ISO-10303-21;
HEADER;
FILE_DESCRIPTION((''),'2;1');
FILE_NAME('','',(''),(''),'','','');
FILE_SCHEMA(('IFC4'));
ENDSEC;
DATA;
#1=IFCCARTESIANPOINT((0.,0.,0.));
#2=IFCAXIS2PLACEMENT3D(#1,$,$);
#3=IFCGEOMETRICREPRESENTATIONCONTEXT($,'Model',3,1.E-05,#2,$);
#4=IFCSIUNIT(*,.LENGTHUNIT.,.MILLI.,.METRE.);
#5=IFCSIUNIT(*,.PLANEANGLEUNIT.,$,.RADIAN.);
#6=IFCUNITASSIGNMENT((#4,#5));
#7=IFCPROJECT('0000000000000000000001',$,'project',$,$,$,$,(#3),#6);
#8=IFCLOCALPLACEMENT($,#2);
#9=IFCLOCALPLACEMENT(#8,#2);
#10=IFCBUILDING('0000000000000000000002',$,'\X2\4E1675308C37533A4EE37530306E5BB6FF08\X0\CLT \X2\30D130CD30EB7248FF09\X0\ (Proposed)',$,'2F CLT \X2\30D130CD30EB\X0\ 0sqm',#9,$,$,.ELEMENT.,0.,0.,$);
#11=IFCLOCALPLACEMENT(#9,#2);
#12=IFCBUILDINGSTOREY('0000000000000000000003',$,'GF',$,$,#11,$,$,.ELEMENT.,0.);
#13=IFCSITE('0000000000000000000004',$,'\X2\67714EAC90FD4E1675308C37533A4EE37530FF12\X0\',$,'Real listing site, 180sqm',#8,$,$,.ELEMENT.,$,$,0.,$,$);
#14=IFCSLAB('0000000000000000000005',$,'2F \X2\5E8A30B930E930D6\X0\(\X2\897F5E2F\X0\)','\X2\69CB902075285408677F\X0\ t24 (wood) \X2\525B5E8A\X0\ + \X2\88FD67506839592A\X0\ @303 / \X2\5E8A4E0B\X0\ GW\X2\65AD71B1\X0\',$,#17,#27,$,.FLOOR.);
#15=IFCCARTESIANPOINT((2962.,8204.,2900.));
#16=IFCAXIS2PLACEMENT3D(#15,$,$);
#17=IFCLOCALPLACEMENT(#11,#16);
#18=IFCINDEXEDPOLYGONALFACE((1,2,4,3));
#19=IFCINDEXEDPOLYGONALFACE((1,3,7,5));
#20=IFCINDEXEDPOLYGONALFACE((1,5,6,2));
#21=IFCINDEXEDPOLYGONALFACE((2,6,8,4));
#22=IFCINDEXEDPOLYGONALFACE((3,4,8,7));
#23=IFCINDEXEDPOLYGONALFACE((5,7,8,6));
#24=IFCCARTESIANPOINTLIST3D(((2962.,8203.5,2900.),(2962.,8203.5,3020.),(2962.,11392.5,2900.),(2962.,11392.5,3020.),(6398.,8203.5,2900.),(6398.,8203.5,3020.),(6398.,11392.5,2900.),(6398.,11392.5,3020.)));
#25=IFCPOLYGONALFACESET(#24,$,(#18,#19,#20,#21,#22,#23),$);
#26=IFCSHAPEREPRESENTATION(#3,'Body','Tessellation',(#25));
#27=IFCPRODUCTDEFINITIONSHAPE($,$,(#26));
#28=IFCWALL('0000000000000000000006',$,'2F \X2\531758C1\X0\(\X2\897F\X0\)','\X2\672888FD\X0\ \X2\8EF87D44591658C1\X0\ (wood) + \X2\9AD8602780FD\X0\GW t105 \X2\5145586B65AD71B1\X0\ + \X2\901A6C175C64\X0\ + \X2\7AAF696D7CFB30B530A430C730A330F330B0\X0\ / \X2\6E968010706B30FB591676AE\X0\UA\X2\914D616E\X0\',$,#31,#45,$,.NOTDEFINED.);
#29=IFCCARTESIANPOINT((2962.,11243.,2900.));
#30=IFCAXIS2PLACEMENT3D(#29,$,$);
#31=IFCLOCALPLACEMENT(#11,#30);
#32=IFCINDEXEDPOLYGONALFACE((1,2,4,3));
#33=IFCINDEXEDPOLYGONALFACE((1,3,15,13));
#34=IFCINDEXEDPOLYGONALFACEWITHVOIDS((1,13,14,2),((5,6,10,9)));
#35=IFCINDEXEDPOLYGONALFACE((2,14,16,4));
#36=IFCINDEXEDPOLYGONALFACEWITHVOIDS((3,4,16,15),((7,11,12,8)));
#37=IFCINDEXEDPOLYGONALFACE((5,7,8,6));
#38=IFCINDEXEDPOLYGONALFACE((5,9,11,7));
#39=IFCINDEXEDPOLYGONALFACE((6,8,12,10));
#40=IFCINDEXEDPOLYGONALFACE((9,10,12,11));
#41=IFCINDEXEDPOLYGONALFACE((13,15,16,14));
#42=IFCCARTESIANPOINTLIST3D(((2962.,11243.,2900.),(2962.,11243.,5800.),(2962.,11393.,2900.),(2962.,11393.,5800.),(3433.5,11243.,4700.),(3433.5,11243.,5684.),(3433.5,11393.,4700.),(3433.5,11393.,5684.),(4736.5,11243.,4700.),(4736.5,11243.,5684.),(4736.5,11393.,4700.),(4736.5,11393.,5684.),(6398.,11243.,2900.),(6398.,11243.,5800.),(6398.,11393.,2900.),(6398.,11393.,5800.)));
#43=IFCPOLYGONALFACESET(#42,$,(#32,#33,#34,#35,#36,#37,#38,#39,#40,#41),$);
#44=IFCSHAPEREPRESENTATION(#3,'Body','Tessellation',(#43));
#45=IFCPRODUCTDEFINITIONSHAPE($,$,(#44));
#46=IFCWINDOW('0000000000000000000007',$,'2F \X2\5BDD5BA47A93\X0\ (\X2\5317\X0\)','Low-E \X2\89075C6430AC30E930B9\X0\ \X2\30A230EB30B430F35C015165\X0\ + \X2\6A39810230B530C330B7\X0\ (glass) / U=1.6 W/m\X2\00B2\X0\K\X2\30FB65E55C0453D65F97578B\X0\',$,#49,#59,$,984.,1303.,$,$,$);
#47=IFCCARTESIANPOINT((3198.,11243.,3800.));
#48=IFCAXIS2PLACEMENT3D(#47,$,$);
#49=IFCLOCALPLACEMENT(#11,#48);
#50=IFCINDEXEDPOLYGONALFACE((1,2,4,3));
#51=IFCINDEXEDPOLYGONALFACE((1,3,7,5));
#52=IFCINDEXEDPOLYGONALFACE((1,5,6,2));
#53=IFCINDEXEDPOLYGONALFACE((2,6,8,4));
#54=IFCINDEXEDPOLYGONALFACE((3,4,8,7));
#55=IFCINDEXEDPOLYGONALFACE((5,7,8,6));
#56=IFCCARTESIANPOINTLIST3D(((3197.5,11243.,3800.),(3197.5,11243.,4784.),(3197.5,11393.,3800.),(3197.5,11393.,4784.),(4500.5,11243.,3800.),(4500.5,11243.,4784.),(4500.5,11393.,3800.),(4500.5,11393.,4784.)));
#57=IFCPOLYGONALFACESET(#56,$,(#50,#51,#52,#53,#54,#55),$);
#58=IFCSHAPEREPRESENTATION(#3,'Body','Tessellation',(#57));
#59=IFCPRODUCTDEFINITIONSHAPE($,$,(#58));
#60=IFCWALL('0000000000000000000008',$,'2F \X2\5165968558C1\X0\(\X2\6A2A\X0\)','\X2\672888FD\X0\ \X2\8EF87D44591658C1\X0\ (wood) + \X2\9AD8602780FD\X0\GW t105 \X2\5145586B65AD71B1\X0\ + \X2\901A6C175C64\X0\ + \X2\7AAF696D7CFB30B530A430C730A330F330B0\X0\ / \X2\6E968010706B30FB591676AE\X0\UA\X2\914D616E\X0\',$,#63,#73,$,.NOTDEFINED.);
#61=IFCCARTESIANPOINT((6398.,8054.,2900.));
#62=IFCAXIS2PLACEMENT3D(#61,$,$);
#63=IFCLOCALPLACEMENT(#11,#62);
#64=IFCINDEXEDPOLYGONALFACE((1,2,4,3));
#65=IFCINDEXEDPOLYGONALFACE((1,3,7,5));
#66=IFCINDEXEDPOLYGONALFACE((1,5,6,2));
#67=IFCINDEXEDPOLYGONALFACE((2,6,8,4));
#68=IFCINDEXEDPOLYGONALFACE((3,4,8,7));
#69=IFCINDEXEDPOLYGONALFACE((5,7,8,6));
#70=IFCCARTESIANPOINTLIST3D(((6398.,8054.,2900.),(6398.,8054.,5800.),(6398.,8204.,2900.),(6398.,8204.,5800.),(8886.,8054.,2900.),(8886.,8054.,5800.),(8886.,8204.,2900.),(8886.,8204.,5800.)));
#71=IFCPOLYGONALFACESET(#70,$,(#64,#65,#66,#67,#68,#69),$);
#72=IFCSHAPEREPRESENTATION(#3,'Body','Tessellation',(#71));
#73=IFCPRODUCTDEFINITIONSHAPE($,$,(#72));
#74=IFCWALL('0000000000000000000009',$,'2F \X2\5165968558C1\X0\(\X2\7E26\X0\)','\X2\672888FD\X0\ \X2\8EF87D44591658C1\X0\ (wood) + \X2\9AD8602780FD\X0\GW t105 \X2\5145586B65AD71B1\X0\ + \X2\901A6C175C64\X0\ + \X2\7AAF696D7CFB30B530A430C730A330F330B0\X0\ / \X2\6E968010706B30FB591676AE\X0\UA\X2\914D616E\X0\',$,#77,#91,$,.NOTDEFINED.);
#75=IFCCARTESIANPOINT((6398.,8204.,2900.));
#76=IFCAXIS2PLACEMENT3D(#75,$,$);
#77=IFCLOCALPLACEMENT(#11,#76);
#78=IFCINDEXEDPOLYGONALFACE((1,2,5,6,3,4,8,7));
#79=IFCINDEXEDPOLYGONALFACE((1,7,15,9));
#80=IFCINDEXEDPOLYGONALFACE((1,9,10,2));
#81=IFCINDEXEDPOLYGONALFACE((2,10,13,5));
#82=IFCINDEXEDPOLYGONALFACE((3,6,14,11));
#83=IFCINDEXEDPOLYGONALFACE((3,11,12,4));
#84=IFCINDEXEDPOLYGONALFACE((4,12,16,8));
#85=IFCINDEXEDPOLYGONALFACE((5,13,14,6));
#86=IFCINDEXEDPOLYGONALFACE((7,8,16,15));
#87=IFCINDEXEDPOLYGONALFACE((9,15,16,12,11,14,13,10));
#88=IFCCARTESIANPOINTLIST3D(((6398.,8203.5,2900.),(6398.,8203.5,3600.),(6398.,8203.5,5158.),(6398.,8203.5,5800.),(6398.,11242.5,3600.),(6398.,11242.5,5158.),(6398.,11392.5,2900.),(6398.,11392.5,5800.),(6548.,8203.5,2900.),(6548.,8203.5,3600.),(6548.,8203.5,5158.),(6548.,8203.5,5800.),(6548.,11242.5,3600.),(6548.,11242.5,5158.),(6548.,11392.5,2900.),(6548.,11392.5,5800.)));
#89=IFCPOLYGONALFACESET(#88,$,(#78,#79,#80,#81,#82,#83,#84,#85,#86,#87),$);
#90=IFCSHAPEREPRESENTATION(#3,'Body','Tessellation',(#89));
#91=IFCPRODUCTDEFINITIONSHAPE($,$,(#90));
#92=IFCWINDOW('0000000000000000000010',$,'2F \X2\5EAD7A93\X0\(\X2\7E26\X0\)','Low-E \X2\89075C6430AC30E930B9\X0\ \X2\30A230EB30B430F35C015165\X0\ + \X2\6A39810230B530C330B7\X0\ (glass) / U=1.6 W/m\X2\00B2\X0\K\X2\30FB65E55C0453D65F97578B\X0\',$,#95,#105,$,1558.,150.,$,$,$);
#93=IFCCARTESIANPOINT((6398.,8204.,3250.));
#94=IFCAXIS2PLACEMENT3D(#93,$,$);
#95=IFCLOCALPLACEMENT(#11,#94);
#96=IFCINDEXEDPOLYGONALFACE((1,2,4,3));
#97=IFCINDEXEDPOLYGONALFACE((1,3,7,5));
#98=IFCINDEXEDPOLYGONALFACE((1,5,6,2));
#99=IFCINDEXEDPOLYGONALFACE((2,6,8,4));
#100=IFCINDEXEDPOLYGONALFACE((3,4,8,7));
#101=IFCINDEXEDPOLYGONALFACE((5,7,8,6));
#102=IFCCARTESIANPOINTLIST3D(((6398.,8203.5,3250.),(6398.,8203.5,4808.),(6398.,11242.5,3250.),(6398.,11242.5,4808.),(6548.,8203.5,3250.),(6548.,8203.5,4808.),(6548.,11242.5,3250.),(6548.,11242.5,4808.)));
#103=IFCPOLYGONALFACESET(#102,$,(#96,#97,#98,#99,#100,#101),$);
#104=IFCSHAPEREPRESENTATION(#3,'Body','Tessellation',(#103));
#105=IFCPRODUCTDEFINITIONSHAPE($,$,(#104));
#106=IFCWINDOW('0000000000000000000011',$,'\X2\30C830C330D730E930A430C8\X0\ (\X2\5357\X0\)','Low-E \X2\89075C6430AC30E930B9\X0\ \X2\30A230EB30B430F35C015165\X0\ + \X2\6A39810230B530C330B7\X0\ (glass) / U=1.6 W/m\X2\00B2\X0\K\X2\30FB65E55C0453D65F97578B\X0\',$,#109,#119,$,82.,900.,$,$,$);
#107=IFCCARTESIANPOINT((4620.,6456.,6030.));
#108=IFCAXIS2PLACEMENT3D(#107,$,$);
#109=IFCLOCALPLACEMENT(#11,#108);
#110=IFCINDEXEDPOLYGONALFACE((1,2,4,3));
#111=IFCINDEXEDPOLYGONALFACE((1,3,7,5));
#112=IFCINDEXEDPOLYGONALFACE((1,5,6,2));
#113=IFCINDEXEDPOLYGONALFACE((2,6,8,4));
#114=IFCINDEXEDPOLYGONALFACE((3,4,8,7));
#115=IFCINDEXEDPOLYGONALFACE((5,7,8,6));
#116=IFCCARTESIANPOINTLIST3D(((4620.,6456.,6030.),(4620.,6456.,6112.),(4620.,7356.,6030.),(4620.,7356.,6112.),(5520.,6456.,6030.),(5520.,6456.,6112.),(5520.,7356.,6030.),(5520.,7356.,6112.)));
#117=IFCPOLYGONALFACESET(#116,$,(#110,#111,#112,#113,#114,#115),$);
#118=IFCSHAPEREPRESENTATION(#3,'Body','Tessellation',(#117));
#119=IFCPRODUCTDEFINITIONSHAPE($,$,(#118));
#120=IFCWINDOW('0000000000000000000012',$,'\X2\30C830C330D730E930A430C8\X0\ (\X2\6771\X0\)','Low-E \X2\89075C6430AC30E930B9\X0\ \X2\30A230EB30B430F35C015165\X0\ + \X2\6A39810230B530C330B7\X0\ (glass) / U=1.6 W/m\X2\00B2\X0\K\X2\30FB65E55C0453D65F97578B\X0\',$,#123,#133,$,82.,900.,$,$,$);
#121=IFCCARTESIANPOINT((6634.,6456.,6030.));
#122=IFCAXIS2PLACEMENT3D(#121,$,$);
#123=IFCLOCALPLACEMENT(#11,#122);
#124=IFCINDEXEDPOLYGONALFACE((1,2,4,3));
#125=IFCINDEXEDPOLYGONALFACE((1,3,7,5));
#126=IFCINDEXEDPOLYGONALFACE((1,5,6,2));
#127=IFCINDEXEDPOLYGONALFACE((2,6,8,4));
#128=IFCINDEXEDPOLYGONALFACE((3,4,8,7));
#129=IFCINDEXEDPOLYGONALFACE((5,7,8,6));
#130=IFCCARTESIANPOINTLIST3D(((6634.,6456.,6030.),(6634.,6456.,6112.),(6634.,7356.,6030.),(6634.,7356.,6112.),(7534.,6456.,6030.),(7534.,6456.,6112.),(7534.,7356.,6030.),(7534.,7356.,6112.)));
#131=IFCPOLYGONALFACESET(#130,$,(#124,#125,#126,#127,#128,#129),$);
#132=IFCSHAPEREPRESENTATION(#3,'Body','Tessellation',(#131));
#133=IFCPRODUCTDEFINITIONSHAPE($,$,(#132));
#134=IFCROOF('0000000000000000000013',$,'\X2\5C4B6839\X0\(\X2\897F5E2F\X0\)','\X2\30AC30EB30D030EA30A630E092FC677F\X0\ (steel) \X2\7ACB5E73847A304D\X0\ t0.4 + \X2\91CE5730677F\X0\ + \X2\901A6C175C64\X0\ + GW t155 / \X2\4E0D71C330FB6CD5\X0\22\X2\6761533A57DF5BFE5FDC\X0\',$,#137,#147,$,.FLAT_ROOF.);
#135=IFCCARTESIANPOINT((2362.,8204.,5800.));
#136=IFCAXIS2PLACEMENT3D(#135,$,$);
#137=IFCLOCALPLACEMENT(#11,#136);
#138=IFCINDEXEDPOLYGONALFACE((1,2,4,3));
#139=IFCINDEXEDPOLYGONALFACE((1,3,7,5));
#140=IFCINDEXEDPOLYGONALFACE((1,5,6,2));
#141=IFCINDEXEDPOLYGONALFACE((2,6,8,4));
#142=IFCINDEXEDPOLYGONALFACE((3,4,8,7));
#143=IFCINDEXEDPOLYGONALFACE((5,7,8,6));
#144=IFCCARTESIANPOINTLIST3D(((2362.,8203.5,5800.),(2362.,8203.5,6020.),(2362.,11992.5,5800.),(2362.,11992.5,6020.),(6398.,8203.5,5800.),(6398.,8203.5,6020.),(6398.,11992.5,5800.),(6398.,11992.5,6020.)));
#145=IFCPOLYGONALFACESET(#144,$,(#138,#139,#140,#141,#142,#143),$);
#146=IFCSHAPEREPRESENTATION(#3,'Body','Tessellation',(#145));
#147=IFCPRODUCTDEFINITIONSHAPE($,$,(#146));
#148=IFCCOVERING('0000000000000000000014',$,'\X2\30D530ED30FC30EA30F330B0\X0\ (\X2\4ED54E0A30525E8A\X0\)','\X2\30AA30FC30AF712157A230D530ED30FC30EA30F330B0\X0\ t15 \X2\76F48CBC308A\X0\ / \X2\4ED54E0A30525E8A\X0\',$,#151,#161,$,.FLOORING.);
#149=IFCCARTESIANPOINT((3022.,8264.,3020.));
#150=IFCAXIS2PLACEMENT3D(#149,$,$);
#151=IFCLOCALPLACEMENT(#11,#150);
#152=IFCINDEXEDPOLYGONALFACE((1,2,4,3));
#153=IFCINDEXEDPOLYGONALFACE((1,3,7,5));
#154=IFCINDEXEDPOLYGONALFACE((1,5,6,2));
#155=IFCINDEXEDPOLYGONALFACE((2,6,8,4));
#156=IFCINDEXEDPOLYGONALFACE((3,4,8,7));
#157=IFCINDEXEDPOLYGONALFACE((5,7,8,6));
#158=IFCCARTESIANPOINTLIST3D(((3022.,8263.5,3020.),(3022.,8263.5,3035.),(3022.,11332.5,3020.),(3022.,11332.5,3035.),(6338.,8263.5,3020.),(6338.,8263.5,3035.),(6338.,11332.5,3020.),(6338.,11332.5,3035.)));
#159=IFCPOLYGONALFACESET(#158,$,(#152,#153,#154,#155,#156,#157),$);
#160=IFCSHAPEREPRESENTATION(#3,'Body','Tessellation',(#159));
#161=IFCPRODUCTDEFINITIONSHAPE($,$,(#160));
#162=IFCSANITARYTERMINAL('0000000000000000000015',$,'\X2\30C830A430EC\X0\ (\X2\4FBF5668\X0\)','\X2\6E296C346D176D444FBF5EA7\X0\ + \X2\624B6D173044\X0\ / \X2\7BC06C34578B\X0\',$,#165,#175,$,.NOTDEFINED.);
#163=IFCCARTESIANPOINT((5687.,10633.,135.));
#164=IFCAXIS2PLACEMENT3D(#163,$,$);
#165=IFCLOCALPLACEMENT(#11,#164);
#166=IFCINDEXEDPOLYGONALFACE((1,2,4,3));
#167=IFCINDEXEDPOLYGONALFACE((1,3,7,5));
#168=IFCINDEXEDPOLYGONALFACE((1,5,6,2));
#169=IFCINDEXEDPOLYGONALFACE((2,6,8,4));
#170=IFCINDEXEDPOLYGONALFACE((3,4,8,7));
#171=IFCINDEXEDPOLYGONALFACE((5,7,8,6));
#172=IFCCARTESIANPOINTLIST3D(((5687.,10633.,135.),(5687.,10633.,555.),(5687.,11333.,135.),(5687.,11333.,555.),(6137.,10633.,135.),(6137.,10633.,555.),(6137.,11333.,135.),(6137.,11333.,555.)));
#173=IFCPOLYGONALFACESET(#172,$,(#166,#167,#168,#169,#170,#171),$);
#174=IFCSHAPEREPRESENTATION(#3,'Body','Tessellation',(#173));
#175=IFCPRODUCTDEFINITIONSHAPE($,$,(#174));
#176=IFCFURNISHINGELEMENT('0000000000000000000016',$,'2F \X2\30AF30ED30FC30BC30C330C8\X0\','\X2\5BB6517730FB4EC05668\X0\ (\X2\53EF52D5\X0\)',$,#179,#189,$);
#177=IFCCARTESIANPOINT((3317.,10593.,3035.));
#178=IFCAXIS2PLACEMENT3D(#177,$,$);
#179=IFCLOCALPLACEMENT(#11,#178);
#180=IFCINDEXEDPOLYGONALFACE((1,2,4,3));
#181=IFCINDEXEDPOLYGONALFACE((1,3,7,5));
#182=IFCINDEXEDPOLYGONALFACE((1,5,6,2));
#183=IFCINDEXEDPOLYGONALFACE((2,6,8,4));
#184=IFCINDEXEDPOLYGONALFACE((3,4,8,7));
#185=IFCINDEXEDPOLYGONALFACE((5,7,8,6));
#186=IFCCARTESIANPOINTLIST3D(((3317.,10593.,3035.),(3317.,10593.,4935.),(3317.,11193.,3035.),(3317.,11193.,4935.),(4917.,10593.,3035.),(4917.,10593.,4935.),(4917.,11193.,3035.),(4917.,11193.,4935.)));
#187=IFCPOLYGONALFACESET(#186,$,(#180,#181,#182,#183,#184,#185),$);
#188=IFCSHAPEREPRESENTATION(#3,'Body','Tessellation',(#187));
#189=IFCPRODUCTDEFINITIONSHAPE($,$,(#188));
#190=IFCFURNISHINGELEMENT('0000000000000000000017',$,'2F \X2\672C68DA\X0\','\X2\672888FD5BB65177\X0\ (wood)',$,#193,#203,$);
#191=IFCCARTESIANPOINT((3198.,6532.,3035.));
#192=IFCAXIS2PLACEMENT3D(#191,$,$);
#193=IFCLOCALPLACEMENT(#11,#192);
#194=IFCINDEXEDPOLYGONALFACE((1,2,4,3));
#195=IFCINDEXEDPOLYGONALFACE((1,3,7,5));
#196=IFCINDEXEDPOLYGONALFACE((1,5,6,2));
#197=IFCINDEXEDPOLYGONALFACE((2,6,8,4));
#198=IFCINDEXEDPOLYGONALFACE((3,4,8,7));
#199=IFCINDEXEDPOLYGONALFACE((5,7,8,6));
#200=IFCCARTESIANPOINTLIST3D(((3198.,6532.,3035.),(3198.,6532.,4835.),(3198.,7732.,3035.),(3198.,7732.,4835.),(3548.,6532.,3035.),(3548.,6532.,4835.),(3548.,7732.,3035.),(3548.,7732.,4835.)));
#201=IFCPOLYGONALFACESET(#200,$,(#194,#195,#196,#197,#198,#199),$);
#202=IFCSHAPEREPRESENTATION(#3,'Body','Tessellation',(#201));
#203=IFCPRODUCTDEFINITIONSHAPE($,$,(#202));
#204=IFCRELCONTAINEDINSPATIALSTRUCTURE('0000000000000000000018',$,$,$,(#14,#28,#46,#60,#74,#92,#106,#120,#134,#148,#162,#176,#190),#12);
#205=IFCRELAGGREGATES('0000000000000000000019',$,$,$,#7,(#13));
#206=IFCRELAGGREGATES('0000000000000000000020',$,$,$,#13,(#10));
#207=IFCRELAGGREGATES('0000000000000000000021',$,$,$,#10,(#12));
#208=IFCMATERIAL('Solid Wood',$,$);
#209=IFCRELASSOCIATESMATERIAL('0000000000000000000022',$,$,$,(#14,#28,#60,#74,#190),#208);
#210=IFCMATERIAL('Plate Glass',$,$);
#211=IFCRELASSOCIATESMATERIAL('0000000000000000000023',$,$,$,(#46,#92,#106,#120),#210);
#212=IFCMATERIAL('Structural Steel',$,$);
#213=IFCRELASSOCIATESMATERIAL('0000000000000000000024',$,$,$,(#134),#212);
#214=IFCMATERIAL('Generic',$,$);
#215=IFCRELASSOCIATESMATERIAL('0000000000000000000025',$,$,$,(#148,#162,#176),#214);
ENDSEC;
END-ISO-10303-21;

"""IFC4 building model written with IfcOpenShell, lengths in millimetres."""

from ifc_helpers import new_model, si_unit, frame, frame_2d, origin, place, context, project, spatial, rectangle, extrude, material, element, fill, save


model = new_model("IFC4")

# Units and contexts
model_context = context("Model", 3, precision=1e-05, world=origin())
ifc_project = project(units=[si_unit("LENGTHUNIT", "METRE", prefix="MILLI"), si_unit("PLANEANGLEUNIT", "RADIAN")], contexts=[model_context])

# Site, building, storey
site_placement = place(None, origin())
site = spatial("IfcSite", under=ifc_project, at=site_placement, Name="東京都世田谷区代田２", ObjectType="Real listing site, 180sqm", CompositionType="ELEMENT", RefElevation=0.0)
building_placement = place(site_placement, origin())
building = spatial("IfcBuilding", under=site, at=building_placement, Name="世田谷区代田の家（CLT パネル版） (Proposed)", ObjectType="2F CLT パネル 0sqm", CompositionType="ELEMENT", ElevationOfRefHeight=0.0, ElevationOfTerrain=0.0)
storey_placement = place(building_placement, origin())
storey = spatial("IfcBuildingStorey", under=building, at=storey_placement, Name="GF", CompositionType="ELEMENT", Elevation=0.0)

# Slab
ifc_material_1 = material(Name="Solid Wood")
slab_placement = place(storey_placement, frame((2962.0, 8204.0, 2900.0)))
element("IfcSlab", 1, at=slab_placement, inside=storey, material=ifc_material_1, Name="2F 床スラブ(西帯)", Description="構造用合板 t24 (wood) 剛床 + 製材根太 @303 / 床下 GW断熱", PredefinedType="FLOOR", context=model_context, shape_type="SweptSolid", body=[
    extrude(rectangle(XDim=3436.0, YDim=3189.0, at=frame_2d((1718.0, 1594.0))), frame((2962.0, 8204.0, 2900.0)), (0.0, 0.0, 1.0), 120.0),
])

# Wall, opening, window
wall_1_placement = place(storey_placement, frame((2962.0, 11243.0, 2900.0)))
wall_1 = element("IfcWall", 2, at=wall_1_placement, inside=storey, material=ifc_material_1, Name="2F 北壁(西)", Description="木製 軸組外壁 (wood) + 高性能GW t105 充填断熱 + 通気層 + 窯業系サイディング / 準耐火・外皮UA配慮", PredefinedType="NOTDEFINED", context=model_context, shape_type="SweptSolid", body=[
    extrude(rectangle(XDim=3436.0, YDim=150.0, at=frame_2d((1718.0, 75.0))), frame((2962.0, 11243.0, 2900.0)), (0.0, 0.0, 1.0), 2900.0),
])
opening_1_placement = place(storey_placement, frame((3198.0, 11243.0, 3800.0)))
opening_1 = element("IfcOpeningElement", 3, at=opening_1_placement, cuts=wall_1, PredefinedType="NOTDEFINED", context=model_context, shape_type="SweptSolid", body=[
    extrude(rectangle(XDim=1303.0, YDim=150.0, at=frame_2d((651.0, 75.0))), frame((3198.0, 11243.0, 3800.0)), (0.0, 0.0, 1.0), 984.0),
])
ifc_material_2 = material(Name="Plate Glass")
window_1_placement = place(storey_placement, frame((3198.0, 11243.0, 3800.0)))
window_1 = element("IfcWindow", 4, at=window_1_placement, inside=storey, material=ifc_material_2, Name="2F 寝室窓 (北)", Description="Low-E 複層ガラス アルゴン封入 + 樹脂サッシ (glass) / U=1.6 W/m²K・日射取得型", OverallHeight=984.0, OverallWidth=1303.0, context=model_context, shape_type="SweptSolid", body=[
    extrude(rectangle(XDim=1303.0, YDim=150.0, at=frame_2d((651.0, 75.0))), frame((3198.0, 11243.0, 3800.0)), (0.0, 0.0, 1.0), 984.0),
])
fill(opening_1, window_1)

# Wall
wall_2_placement = place(storey_placement, frame((6398.0, 8054.0, 2900.0)))
element("IfcWall", 5, at=wall_2_placement, inside=storey, material=ifc_material_1, Name="2F 入隅壁(横)", Description="木製 軸組外壁 (wood) + 高性能GW t105 充填断熱 + 通気層 + 窯業系サイディング / 準耐火・外皮UA配慮", PredefinedType="NOTDEFINED", context=model_context, shape_type="SweptSolid", body=[
    extrude(rectangle(XDim=2488.0, YDim=150.0, at=frame_2d((1244.0, 75.0))), frame((6398.0, 8054.0, 2900.0)), (0.0, 0.0, 1.0), 2900.0),
])

# Wall, opening, window
wall_3_placement = place(storey_placement, frame((6398.0, 8204.0, 2900.0)))
wall_3 = element("IfcWall", 6, at=wall_3_placement, inside=storey, material=ifc_material_1, Name="2F 入隅壁(縦)", Description="木製 軸組外壁 (wood) + 高性能GW t105 充填断熱 + 通気層 + 窯業系サイディング / 準耐火・外皮UA配慮", PredefinedType="NOTDEFINED", context=model_context, shape_type="SweptSolid", body=[
    extrude(rectangle(XDim=150.0, YDim=3189.0, at=frame_2d((75.0, 1594.0))), frame((6398.0, 8204.0, 2900.0)), (0.0, 0.0, 1.0), 2900.0),
])
opening_2_placement = place(storey_placement, frame((6398.0, 8204.0, 3250.0)))
opening_2 = element("IfcOpeningElement", 7, at=opening_2_placement, cuts=wall_3, PredefinedType="NOTDEFINED", context=model_context, shape_type="SweptSolid", body=[
    extrude(rectangle(XDim=150.0, YDim=3039.0, at=frame_2d((75.0, 1519.0))), frame((6398.0, 8204.0, 3250.0)), (0.0, 0.0, 1.0), 1558.0),
])
window_2_placement = place(storey_placement, frame((6398.0, 8204.0, 3250.0)))
window_2 = element("IfcWindow", 8, at=window_2_placement, inside=storey, material=ifc_material_2, Name="2F 庭窓(縦)", Description="Low-E 複層ガラス アルゴン封入 + 樹脂サッシ (glass) / U=1.6 W/m²K・日射取得型", OverallHeight=1558.0, OverallWidth=150.0, context=model_context, shape_type="SweptSolid", body=[
    extrude(rectangle(XDim=150.0, YDim=3039.0, at=frame_2d((75.0, 1519.0))), frame((6398.0, 8204.0, 3250.0)), (0.0, 0.0, 1.0), 1558.0),
])
fill(opening_2, window_2)

# Windows
window_3_placement = place(storey_placement, frame((4620.0, 6456.0, 6030.0)))
element("IfcWindow", 9, at=window_3_placement, inside=storey, material=ifc_material_2, Name="トップライト (南)", Description="Low-E 複層ガラス アルゴン封入 + 樹脂サッシ (glass) / U=1.6 W/m²K・日射取得型", OverallHeight=82.0, OverallWidth=900.0, context=model_context, shape_type="SweptSolid", body=[
    extrude(rectangle(XDim=900.0, YDim=900.0, at=frame_2d((450.0, 450.0))), frame((4620.0, 6456.0, 6030.0)), (0.0, 0.0, 1.0), 82.0),
])
window_4_placement = place(storey_placement, frame((6634.0, 6456.0, 6030.0)))
element("IfcWindow", 10, at=window_4_placement, inside=storey, material=ifc_material_2, Name="トップライト (東)", Description="Low-E 複層ガラス アルゴン封入 + 樹脂サッシ (glass) / U=1.6 W/m²K・日射取得型", OverallHeight=82.0, OverallWidth=900.0, context=model_context, shape_type="SweptSolid", body=[
    extrude(rectangle(XDim=900.0, YDim=900.0, at=frame_2d((450.0, 450.0))), frame((6634.0, 6456.0, 6030.0)), (0.0, 0.0, 1.0), 82.0),
])

# Roof
ifc_material_3 = material(Name="Structural Steel")
for number, where, name in (
    (11, (2362.0, 8204.0, 5800.0), "屋根(西帯)"),
):
    element("IfcRoof", number, at=place(storey_placement, frame(where)), inside=storey, material=ifc_material_3, Name=name, Description="ガルバリウム鋼板 (steel) 立平葺き t0.4 + 野地板 + 通気層 + GW t155 / 不燃・法22条区域対応", PredefinedType="FLAT_ROOF", context=model_context, shape_type="SweptSolid", body=[
        extrude(rectangle(XDim=4036.0, YDim=3789.0, at=frame_2d((2018.0, 1894.0))), frame((2362.0, 8204.0, 5800.0)), (0.0, 0.0, 1.0), 220.0),
    ])

# Covering
ifc_material_4 = material(Name="Generic")
covering_placement = place(storey_placement, frame((3022.0, 8264.0, 3020.0)))
element("IfcCovering", 12, at=covering_placement, inside=storey, material=ifc_material_4, Name="フローリング (仕上げ床)", Description="オーク無垢フローリング t15 直貼り / 仕上げ床", PredefinedType="FLOORING", context=model_context, shape_type="SweptSolid", body=[
    extrude(rectangle(XDim=3316.0, YDim=3069.0, at=frame_2d((1658.0, 1534.0))), frame((3022.0, 8264.0, 3020.0)), (0.0, 0.0, 1.0), 15.0),
])

# Sanitary terminal
sanitary_terminal_placement = place(storey_placement, frame((5687.0, 10633.0, 135.0)))
element("IfcSanitaryTerminal", 13, at=sanitary_terminal_placement, inside=storey, material=ifc_material_4, Name="トイレ (便器)", Description="温水洗浄便座 + 手洗い / 節水型", PredefinedType="NOTDEFINED", context=model_context, shape_type="SweptSolid", body=[
    extrude(rectangle(XDim=450.0, YDim=700.0, at=frame_2d((225.0, 350.0))), frame((5687.0, 10633.0, 135.0)), (0.0, 0.0, 1.0), 420.0),
])

# Furnishing elements
furnishing_1_placement = place(storey_placement, frame((3317.0, 10593.0, 3035.0)))
element("IfcFurnishingElement", 14, at=furnishing_1_placement, inside=storey, material=ifc_material_4, Name="2F クローゼット", Description="家具・什器 (可動)", context=model_context, shape_type="SweptSolid", body=[
    extrude(rectangle(XDim=1600.0, YDim=600.0, at=frame_2d((800.0, 300.0))), frame((3317.0, 10593.0, 3035.0)), (0.0, 0.0, 1.0), 1900.0),
])
furnishing_2_placement = place(storey_placement, frame((3198.0, 6532.0, 3035.0)))
element("IfcFurnishingElement", 15, at=furnishing_2_placement, inside=storey, material=ifc_material_1, Name="2F 本棚", Description="木製家具 (wood)", context=model_context, shape_type="SweptSolid", body=[
    extrude(rectangle(XDim=350.0, YDim=1200.0, at=frame_2d((175.0, 600.0))), frame((3198.0, 6532.0, 3035.0)), (0.0, 0.0, 1.0), 1800.0),
])

save(model, "model.ifc")
